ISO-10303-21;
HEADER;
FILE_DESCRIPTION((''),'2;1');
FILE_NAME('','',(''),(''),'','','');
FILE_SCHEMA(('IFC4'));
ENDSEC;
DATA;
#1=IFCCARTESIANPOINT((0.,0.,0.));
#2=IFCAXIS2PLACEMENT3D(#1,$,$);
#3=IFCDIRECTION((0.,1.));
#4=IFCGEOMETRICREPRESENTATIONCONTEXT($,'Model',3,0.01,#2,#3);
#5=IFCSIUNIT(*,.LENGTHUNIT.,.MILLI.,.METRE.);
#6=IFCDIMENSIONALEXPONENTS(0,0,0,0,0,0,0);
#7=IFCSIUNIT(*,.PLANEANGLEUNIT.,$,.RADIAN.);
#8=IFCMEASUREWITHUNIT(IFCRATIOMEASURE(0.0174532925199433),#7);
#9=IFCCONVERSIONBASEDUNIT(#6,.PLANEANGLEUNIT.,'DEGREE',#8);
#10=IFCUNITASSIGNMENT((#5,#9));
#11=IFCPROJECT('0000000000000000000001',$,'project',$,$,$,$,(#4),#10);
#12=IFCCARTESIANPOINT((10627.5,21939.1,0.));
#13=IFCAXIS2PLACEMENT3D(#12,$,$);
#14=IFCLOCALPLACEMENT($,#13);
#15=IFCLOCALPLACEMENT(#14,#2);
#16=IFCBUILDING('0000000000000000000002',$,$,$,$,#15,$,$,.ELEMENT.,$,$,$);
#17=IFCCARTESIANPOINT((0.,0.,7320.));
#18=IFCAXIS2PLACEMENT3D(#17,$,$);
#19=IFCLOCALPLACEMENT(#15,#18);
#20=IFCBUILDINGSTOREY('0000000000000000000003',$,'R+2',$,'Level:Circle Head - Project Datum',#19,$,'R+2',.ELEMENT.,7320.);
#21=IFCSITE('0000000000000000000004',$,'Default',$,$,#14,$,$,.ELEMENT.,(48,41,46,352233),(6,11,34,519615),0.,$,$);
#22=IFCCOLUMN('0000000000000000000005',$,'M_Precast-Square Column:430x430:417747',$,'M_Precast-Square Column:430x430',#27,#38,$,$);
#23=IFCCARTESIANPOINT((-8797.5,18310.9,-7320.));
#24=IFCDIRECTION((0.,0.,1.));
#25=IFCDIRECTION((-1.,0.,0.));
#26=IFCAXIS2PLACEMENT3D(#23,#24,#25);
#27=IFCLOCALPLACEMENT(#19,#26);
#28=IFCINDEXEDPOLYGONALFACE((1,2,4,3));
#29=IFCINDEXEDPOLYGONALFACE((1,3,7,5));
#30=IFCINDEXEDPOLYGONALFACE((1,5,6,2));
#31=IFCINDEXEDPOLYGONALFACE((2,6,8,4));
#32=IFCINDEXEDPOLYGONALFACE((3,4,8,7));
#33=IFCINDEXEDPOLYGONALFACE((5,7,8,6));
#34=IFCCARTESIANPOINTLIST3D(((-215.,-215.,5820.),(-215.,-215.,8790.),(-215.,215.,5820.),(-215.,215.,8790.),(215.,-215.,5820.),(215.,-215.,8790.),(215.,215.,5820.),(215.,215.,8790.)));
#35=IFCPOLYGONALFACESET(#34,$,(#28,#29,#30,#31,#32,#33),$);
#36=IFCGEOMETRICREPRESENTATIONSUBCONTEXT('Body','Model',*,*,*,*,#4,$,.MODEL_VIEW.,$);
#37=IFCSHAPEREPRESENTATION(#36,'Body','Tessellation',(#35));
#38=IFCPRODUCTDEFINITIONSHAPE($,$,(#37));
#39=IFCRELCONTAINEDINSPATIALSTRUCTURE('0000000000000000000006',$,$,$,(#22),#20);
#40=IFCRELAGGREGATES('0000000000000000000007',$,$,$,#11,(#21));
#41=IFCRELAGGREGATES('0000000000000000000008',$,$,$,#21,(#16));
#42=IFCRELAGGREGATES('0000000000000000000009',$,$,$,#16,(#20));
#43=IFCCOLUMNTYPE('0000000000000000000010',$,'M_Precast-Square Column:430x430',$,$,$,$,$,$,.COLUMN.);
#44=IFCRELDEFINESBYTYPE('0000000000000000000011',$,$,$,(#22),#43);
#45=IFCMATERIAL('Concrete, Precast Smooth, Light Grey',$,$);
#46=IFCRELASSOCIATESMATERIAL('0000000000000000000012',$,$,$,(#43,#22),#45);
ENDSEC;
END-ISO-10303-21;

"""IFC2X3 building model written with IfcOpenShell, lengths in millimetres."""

from ifc_helpers import new_model, entity, si_unit, converted_unit, direction, frame, origin, origin_2d_with_axis, place, context, subcontext, project, spatial, rectangle, extrude, source, transform, mapped, material, type_object, type_shapes, element, save


model = new_model("IFC2X3")

# Units and contexts
model_context = context("Model", 3, precision=0.01, world=origin(), true_north=direction((0.0, 1.0)))
body_context = subcontext(model_context, "Body", "Model", "MODEL_VIEW")
ifc_project = project(units=[si_unit("LENGTHUNIT", "METRE", prefix="MILLI"), converted_unit("PLANEANGLEUNIT", "DEGREE", entity("IfcRatioMeasure", 0.0174532925199433), si_unit("PLANEANGLEUNIT", "RADIAN"), dimensions=[0, 0, 0, 0, 0, 0, 0])], contexts=[model_context])

# Site, building, storey
site_placement = place(None, frame((10627.5, 21939.1, 0.0)))
site = spatial("IfcSite", under=ifc_project, at=site_placement, Name="Default", CompositionType="ELEMENT", RefLatitude=(48, 41, 46, 352233), RefLongitude=(6, 11, 34, 519615), RefElevation=0.0)
building_placement = place(site_placement, origin())
building = spatial("IfcBuilding", under=site, at=building_placement, CompositionType="ELEMENT")
storey_placement = place(building_placement, frame((0.0, 0.0, 7320.0)))
storey = spatial("IfcBuildingStorey", under=building, at=storey_placement, Name="R+2", ObjectType="Level:Circle Head - Project Datum", LongName="R+2", CompositionType="ELEMENT", Elevation=7320.0)

# Column
ifc_material = material(Name="Concrete, Precast Smooth, Light Grey")
column_type_1 = type_object("IfcColumnType", Name="M_Precast-Square Column:430x430", PredefinedType="COLUMN", material=ifc_material)
shared_shape_1 = source(origin(), body_context, "Body", "SweptSolid", [
    extrude(rectangle(XDim=430.0, YDim=430.0, at=origin_2d_with_axis()), frame((0.0, 0.0, 5820.0), z_axis=(0.0, 0.0, 1.0), x_axis=(0.0, -1.0, 0.0)), (0.0, 0.0, 1.0), 2970.0),
])
type_shapes(column_type_1, [shared_shape_1])
column_1_placement = place(storey_placement, frame((-8797.5, 18310.9, -7320.0), z_axis=(0.0, 0.0, 1.0), x_axis=(-1.0, 0.0, 0.0)))
element("IfcColumn", 1, at=column_1_placement, inside=storey, type_object=column_type_1, material=ifc_material, Name="M_Precast-Square Column:430x430:417747", ObjectType="M_Precast-Square Column:430x430", context=body_context, shape_type="MappedRepresentation", body=[
    mapped(shared_shape_1, transform((0.0, 0.0, 0.0), scale=1.0)),
])

save(model, "model.ifc")
